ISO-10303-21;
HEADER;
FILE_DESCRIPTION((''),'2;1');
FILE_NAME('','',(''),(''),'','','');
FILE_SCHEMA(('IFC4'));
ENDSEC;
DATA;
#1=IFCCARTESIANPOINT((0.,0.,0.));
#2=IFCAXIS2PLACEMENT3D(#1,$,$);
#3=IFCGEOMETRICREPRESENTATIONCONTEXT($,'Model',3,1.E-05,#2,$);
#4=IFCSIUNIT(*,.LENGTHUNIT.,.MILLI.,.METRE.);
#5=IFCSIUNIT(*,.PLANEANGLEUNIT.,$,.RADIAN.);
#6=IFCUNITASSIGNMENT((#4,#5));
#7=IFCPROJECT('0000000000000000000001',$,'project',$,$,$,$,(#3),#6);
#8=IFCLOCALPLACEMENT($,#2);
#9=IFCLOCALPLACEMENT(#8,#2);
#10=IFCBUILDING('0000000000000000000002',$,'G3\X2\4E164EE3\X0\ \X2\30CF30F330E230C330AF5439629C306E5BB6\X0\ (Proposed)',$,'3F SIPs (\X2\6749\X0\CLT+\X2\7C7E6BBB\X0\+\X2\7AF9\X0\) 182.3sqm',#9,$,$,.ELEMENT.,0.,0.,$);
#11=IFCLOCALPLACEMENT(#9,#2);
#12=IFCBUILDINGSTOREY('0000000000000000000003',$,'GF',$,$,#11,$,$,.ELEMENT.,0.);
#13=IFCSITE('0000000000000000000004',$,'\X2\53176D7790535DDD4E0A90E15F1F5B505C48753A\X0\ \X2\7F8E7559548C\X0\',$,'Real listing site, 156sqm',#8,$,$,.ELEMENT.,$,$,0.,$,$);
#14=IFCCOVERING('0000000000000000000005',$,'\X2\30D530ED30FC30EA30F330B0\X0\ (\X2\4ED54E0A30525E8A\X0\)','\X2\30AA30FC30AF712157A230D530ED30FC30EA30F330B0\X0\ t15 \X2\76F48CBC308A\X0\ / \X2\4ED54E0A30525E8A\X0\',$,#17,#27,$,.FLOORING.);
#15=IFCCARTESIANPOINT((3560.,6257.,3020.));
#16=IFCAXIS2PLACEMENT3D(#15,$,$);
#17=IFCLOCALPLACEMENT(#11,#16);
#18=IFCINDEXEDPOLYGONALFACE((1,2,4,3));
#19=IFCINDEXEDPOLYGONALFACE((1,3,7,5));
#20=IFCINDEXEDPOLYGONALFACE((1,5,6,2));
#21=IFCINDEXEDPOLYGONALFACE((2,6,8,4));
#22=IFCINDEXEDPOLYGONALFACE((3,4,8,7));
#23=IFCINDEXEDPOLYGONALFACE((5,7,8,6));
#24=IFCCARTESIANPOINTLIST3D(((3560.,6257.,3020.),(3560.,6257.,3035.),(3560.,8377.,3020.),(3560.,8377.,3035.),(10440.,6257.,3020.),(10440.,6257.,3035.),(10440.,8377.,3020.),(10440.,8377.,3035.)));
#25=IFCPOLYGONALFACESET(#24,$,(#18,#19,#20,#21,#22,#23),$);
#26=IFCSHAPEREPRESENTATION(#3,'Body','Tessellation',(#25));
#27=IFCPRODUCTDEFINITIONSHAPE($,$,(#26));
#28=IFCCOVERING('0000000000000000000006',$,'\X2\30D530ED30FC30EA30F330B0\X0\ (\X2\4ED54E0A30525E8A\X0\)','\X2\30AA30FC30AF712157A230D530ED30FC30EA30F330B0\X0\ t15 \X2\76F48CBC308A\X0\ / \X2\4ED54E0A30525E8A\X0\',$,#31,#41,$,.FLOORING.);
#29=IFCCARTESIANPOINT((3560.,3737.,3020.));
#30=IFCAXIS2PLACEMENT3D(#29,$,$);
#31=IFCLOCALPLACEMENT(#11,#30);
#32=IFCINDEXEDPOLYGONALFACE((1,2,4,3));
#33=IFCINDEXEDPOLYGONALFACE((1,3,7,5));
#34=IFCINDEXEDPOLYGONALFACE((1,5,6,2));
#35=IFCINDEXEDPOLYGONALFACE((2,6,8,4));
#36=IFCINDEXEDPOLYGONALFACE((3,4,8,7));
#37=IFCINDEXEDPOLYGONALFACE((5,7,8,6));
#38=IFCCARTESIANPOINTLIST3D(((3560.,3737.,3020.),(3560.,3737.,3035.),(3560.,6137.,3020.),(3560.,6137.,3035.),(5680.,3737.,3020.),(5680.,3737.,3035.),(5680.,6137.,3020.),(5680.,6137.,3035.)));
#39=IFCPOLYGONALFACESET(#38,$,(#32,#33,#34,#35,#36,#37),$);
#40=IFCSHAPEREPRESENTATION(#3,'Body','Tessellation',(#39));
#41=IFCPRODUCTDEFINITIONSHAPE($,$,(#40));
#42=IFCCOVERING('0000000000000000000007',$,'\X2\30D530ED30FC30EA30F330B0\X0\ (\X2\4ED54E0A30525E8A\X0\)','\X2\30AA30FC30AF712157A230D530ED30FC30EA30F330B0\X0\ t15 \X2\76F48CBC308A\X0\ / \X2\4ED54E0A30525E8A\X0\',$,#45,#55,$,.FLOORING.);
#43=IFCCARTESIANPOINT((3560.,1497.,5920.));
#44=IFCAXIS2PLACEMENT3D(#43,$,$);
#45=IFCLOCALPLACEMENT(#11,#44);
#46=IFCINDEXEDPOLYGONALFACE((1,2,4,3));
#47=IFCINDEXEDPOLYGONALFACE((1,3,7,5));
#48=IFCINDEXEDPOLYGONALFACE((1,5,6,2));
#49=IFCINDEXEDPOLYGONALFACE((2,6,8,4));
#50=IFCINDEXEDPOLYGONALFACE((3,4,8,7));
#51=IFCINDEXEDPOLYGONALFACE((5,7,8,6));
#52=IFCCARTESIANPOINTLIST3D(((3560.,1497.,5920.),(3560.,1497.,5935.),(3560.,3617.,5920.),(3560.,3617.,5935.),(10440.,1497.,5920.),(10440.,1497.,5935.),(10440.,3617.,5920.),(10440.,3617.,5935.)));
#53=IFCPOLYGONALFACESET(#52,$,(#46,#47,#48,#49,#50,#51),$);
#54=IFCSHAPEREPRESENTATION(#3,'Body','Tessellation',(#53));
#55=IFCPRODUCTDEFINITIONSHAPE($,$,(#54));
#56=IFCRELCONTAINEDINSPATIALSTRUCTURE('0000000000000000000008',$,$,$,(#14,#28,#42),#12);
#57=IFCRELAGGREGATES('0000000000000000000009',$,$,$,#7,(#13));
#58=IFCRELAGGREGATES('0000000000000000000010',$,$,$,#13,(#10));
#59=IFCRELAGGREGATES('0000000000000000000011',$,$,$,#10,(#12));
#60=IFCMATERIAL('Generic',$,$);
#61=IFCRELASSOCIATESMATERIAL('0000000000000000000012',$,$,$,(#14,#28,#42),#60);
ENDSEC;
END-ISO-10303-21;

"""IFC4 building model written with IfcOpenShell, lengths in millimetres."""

from ifc_helpers import new_model, si_unit, frame, frame_2d, origin, place, context, project, spatial, rectangle, extrude, material, element, save


model = new_model("IFC4")

# Units and contexts
model_context = context("Model", 3, precision=1e-05, world=origin())
ifc_project = project(units=[si_unit("LENGTHUNIT", "METRE", prefix="MILLI"), si_unit("PLANEANGLEUNIT", "RADIAN")], contexts=[model_context])

# Site, building, storey
site_placement = place(None, origin())
site = spatial("IfcSite", under=ifc_project, at=site_placement, Name="北海道川上郡弟子屈町 美留和", ObjectType="Real listing site, 156sqm", CompositionType="ELEMENT", RefElevation=0.0)
building_placement = place(site_placement, origin())
building = spatial("IfcBuilding", under=site, at=building_placement, Name="G3世代 ハンモック吹抜の家 (Proposed)", ObjectType="3F SIPs (杉CLT+籾殻+竹) 182.3sqm", CompositionType="ELEMENT", ElevationOfRefHeight=0.0, ElevationOfTerrain=0.0)
storey_placement = place(building_placement, origin())
storey = spatial("IfcBuildingStorey", under=building, at=storey_placement, Name="GF", CompositionType="ELEMENT", Elevation=0.0)

# Shared definitions
ifc_material_1 = material(Name="Generic")

# Coverings
covering_1_placement = place(storey_placement, frame((3560.0, 6257.0, 3020.0)))
element("IfcCovering", 1, at=covering_1_placement, inside=storey, material=ifc_material_1, Name="フローリング (仕上げ床)", Description="オーク無垢フローリング t15 直貼り / 仕上げ床", PredefinedType="FLOORING", context=model_context, shape_type="SweptSolid", body=[
    extrude(rectangle(XDim=6880.0, YDim=2120.0, at=frame_2d((3440.0, 1060.0))), frame((3560.0, 6257.0, 3020.0)), (0.0, 0.0, 1.0), 15.0),
])
covering_2_placement = place(storey_placement, frame((3560.0, 3737.0, 3020.0)))
element("IfcCovering", 2, at=covering_2_placement, inside=storey, material=ifc_material_1, Name="フローリング (仕上げ床)", Description="オーク無垢フローリング t15 直貼り / 仕上げ床", PredefinedType="FLOORING", context=model_context, shape_type="SweptSolid", body=[
    extrude(rectangle(XDim=2120.0, YDim=2400.0, at=frame_2d((1060.0, 1200.0))), frame((3560.0, 3737.0, 3020.0)), (0.0, 0.0, 1.0), 15.0),
])
covering_3_placement = place(storey_placement, frame((3560.0, 1497.0, 5920.0)))
element("IfcCovering", 3, at=covering_3_placement, inside=storey, material=ifc_material_1, Name="フローリング (仕上げ床)", Description="オーク無垢フローリング t15 直貼り / 仕上げ床", PredefinedType="FLOORING", context=model_context, shape_type="SweptSolid", body=[
    extrude(rectangle(XDim=6880.0, YDim=2120.0, at=frame_2d((3440.0, 1060.0))), frame((3560.0, 1497.0, 5920.0)), (0.0, 0.0, 1.0), 15.0),
])

save(model, "model.ifc")
